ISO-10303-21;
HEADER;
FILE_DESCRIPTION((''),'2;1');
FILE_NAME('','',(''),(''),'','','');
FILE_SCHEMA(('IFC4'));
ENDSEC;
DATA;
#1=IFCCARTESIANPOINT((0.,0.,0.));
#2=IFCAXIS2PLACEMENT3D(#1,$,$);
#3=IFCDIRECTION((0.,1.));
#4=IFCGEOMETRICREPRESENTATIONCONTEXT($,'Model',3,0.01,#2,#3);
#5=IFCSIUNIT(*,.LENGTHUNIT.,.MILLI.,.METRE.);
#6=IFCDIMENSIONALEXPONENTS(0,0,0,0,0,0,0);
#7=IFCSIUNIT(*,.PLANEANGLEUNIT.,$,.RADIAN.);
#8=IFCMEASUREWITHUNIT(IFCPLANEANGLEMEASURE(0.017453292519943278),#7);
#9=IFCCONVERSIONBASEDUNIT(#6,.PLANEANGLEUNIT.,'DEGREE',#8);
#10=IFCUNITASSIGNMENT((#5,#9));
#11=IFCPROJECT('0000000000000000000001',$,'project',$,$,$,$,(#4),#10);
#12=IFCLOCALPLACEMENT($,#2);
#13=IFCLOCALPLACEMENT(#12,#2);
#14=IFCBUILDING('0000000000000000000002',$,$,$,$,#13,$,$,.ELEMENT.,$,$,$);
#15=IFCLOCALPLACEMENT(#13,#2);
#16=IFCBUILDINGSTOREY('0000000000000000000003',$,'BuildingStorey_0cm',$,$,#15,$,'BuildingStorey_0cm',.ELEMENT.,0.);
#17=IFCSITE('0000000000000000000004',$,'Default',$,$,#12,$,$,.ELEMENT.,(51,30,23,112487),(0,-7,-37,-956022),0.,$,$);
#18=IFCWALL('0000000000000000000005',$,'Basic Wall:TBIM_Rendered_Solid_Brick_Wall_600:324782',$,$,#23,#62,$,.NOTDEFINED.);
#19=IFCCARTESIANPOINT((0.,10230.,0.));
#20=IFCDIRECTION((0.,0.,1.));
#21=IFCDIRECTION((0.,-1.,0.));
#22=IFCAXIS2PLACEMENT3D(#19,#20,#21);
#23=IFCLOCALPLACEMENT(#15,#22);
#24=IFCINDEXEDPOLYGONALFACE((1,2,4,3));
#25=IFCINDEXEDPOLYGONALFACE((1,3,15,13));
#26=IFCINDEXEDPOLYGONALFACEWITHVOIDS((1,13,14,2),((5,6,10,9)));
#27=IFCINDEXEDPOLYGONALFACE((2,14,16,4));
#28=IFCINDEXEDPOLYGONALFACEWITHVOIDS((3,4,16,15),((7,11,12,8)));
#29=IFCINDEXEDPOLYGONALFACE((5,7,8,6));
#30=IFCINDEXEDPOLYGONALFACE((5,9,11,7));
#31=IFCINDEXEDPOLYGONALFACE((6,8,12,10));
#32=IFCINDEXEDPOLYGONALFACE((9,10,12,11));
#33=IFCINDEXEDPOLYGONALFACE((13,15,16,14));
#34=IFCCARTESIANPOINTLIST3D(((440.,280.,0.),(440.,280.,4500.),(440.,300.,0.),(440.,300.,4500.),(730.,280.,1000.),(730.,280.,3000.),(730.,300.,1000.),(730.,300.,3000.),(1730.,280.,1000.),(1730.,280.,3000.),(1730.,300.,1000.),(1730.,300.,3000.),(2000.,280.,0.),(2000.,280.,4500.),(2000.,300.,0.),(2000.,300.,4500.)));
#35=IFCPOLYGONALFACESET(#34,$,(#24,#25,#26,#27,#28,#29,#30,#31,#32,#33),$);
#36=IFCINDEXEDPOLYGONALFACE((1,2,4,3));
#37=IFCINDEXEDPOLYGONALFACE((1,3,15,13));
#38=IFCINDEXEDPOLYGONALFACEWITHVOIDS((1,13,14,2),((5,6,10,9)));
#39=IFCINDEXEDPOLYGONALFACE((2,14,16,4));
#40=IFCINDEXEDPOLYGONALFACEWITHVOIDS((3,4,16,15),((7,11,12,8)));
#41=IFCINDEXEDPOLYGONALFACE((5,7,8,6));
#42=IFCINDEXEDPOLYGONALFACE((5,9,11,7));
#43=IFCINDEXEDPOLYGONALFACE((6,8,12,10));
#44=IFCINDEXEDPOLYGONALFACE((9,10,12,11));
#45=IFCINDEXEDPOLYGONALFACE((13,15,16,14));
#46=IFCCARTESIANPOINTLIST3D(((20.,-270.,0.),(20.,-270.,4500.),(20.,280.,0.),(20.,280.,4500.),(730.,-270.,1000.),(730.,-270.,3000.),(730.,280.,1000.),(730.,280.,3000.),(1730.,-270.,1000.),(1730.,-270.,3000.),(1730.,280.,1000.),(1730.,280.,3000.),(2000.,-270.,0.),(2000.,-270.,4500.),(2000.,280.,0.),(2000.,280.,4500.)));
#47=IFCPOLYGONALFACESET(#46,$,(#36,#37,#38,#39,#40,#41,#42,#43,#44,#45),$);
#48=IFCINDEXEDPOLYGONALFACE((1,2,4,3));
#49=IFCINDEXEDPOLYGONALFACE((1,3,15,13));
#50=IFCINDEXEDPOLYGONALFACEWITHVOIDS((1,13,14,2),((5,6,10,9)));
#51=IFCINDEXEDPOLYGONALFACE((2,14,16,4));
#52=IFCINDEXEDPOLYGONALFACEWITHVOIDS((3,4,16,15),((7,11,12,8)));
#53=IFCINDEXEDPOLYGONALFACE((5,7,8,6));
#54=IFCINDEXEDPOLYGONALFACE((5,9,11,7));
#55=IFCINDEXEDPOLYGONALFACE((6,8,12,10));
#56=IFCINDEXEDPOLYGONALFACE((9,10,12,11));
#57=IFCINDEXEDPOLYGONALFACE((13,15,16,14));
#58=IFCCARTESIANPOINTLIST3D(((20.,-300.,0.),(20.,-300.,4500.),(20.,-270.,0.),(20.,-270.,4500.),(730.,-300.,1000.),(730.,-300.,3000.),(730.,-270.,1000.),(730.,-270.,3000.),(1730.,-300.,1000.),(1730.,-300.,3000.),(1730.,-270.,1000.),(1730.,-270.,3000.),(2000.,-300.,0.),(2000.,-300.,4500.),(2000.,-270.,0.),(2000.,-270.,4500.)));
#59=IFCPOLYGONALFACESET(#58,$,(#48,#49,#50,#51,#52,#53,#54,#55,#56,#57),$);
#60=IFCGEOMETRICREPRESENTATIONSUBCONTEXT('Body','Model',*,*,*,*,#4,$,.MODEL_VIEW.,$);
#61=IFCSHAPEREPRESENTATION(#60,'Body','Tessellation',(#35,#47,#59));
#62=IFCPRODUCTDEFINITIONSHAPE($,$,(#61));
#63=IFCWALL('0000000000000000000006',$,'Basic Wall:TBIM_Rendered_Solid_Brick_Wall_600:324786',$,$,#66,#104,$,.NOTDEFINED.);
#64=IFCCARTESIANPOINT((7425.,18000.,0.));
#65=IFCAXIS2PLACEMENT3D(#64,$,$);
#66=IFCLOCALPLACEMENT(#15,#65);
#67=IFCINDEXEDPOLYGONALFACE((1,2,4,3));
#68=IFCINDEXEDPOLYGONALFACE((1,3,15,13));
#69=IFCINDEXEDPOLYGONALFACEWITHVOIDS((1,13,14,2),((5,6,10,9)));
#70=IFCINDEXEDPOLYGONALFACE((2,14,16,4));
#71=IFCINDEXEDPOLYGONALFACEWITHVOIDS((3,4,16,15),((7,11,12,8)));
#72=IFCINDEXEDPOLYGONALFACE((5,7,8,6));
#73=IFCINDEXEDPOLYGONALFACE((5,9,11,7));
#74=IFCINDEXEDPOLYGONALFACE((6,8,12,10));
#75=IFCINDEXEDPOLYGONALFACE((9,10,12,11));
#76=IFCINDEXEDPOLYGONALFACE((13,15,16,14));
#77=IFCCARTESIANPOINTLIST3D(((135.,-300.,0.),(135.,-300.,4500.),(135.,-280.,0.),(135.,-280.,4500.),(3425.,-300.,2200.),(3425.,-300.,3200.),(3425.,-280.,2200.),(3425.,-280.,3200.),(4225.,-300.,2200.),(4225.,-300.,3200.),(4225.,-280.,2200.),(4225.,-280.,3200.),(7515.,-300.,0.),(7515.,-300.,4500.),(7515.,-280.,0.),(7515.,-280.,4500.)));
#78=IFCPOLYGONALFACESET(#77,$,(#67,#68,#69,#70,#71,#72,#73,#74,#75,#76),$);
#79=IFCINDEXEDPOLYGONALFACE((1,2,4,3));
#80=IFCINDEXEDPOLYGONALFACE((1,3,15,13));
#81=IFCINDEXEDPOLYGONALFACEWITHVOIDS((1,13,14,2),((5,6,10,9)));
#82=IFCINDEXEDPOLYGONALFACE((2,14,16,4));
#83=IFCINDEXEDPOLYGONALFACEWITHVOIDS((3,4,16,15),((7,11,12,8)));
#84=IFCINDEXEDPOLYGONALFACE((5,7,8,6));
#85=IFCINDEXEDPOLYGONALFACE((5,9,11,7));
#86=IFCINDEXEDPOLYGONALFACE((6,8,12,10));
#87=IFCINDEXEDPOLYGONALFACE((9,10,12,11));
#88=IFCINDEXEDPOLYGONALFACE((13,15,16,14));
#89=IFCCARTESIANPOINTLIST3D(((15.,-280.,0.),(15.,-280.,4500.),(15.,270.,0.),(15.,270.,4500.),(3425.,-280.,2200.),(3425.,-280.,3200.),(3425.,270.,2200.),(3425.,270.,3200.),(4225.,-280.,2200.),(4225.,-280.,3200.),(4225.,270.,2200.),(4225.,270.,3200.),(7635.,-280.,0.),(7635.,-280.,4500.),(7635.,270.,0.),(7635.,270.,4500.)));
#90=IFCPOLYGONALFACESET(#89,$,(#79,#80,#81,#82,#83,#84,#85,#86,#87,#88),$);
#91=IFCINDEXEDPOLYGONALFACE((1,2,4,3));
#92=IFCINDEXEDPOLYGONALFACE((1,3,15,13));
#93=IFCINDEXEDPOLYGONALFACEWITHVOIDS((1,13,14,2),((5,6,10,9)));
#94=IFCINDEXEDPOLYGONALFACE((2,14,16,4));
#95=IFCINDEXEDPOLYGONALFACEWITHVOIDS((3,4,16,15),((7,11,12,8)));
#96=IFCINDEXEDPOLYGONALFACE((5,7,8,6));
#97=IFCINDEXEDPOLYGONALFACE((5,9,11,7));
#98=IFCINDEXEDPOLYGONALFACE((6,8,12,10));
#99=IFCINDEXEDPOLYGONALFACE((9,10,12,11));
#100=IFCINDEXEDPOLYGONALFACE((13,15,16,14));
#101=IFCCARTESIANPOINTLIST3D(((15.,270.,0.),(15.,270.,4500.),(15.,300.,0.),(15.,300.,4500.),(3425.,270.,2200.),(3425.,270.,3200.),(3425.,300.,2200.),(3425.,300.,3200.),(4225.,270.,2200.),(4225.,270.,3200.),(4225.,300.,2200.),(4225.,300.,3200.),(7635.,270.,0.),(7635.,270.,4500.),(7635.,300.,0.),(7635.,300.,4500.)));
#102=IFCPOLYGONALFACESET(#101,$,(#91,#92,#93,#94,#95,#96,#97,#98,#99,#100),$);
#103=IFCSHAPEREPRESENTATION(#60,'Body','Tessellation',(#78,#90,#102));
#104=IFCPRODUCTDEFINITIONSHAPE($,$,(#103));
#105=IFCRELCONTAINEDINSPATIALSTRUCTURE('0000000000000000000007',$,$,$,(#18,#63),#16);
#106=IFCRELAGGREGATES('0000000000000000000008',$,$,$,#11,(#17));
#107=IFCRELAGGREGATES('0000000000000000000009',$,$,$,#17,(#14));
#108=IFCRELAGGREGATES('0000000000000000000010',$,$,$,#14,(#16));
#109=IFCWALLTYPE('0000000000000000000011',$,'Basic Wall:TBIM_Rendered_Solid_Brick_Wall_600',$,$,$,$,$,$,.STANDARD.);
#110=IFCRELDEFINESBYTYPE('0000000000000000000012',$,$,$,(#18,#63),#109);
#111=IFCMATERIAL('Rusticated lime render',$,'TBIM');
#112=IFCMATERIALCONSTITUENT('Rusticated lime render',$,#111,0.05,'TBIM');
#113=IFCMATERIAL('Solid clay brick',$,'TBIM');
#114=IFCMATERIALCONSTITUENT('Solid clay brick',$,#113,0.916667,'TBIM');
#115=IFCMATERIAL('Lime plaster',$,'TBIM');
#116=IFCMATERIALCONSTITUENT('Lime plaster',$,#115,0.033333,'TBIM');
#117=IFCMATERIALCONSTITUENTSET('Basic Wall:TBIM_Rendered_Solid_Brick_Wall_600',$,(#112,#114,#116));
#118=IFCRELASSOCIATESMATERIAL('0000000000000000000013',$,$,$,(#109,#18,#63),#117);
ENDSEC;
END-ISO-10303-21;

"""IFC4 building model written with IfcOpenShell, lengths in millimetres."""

from ifc_helpers import new_model, entity, si_unit, converted_unit, direction, frame, origin, place, context, subcontext, project, spatial, indexed_curve, outline, extrude, material, constituent, constituent_set, type_object, element, save


model = new_model("IFC4")

# Units and contexts
model_context = context("Model", 3, precision=0.01, world=origin(), true_north=direction((0.0, 1.0)))
body_context = subcontext(model_context, "Body", "Model", "MODEL_VIEW")
ifc_project = project(units=[si_unit("LENGTHUNIT", "METRE", prefix="MILLI"), converted_unit("PLANEANGLEUNIT", "DEGREE", entity("IfcPlaneAngleMeasure", 0.017453292519943278), si_unit("PLANEANGLEUNIT", "RADIAN"), dimensions=[0, 0, 0, 0, 0, 0, 0])], contexts=[model_context])

# Site, building, storey
site_placement = place(None, origin())
site = spatial("IfcSite", under=ifc_project, at=site_placement, Name="Default", CompositionType="ELEMENT", RefLatitude=(51, 30, 23, 112487), RefLongitude=(0, -7, -37, -956022), RefElevation=0.0)
building_placement = place(site_placement, origin())
building = spatial("IfcBuilding", under=site, at=building_placement, CompositionType="ELEMENT")
storey_placement = place(building_placement, origin())
storey = spatial("IfcBuildingStorey", under=building, at=storey_placement, Name="BuildingStorey_0cm", LongName="BuildingStorey_0cm", CompositionType="ELEMENT", Elevation=0.0)

# Walls, openings
ifc_material_1 = material(Name="Rusticated lime render", Category="TBIM")
ifc_constituent_1 = constituent(ifc_material_1, Name="Rusticated lime render", Category="TBIM", fraction=0.05)
ifc_material_2 = material(Name="Solid clay brick", Category="TBIM")
ifc_constituent_2 = constituent(ifc_material_2, Name="Solid clay brick", Category="TBIM", fraction=0.916667)
ifc_material_3 = material(Name="Lime plaster", Category="TBIM")
ifc_constituent_3 = constituent(ifc_material_3, Name="Lime plaster", Category="TBIM", fraction=0.033333)
ifc_constituent_set_1 = constituent_set(constituents=[ifc_constituent_1, ifc_constituent_2, ifc_constituent_3], Name="Basic Wall:TBIM_Rendered_Solid_Brick_Wall_600")
wall_type_1 = type_object("IfcWallType", Name="Basic Wall:TBIM_Rendered_Solid_Brick_Wall_600", PredefinedType="STANDARD", material=ifc_constituent_set_1)
wall_1_placement = place(storey_placement, frame((0.0, 10230.0, 0.0), z_axis=(0.0, 0.0, 1.0), x_axis=(0.0, -1.0, 0.0)))
wall_1 = element("IfcWall", 1, at=wall_1_placement, inside=storey, type_object=wall_type_1, material=ifc_constituent_set_1, Name="Basic Wall:TBIM_Rendered_Solid_Brick_Wall_600:324782", PredefinedType="NOTDEFINED", context=body_context, shape_type="SweptSolid", body=[
    extrude(outline(indexed_curve([(-2250.0, -780.0), (2250.0, -780.0), (2250.0, 780.0), (-2250.0, 780.0), (-2250.0, -780.0)], self_intersect=False), holes=[indexed_curve([(-1250.0, -490.0), (-1250.0, 510.0), (750.0, 510.0), (750.0, -490.0), (-1250.0, -490.0)], self_intersect=False)]), frame((1220.0, 280.0, 2250.0), z_axis=(0.0, 1.0, 0.0), x_axis=(0.0, 0.0, 1.0)), (0.0, 0.0, 1.0), 20.0),
    extrude(outline(indexed_curve([(-2250.0, -990.0), (2250.0, -990.0), (2250.0, 990.0), (-2250.0, 990.0), (-2250.0, -990.0)], self_intersect=False), holes=[indexed_curve([(-1250.0, -280.0), (-1250.0, 720.0), (750.0, 720.0), (750.0, -280.0), (-1250.0, -280.0)], self_intersect=False)]), frame((1010.0, -270.0, 2250.0), z_axis=(0.0, 1.0, 0.0), x_axis=(0.0, 0.0, 1.0)), (0.0, 0.0, 1.0), 550.0),
    extrude(outline(indexed_curve([(-2250.0, -990.0), (2250.0, -990.0), (2250.0, 990.0), (-2250.0, 990.0), (-2250.0, -990.0)], self_intersect=False), holes=[indexed_curve([(750.0, -280.0), (-1250.0, -280.0), (-1250.0, 720.0), (750.0, 720.0), (750.0, -280.0)], self_intersect=False)]), frame((1010.0, -300.0, 2250.0), z_axis=(0.0, 1.0, 0.0), x_axis=(0.0, 0.0, 1.0)), (0.0, 0.0, 1.0), 30.0),
])
opening_1_placement = place(wall_1_placement, frame((730.0, -300.0, 1000.0)))
element("IfcOpeningElement", 2, at=opening_1_placement, cuts=wall_1, PredefinedType="OPENING", context=body_context, shape_type="SweptSolid", body=[
    extrude(outline(indexed_curve([(2000.0, 0.0), (2000.0, 1000.0), (0.0, 1000.0), (0.0, 0.0), (2000.0, 0.0)], self_intersect=False)), frame((0.0, 0.0, 0.0), z_axis=(0.0, 1.0, 0.0), x_axis=(0.0, 0.0, 1.0)), (0.0, 0.0, 1.0), 600.0),
])
wall_2_placement = place(storey_placement, frame((7425.0, 18000.0, 0.0)))
wall_2 = element("IfcWall", 3, at=wall_2_placement, inside=storey, type_object=wall_type_1, material=ifc_constituent_set_1, Name="Basic Wall:TBIM_Rendered_Solid_Brick_Wall_600:324786", PredefinedType="NOTDEFINED", context=body_context, shape_type="SweptSolid", body=[
    extrude(outline(indexed_curve([(-2250.0, -3690.0), (2250.0, -3690.0), (2250.0, -3675.0), (2250.0, 3675.0), (2250.0, 3690.0), (-2250.0, 3690.0), (-2250.0, 3675.0), (-2250.0, -3675.0), (-2250.0, -3690.0)], self_intersect=False), holes=[indexed_curve([(950.0, -400.0), (-50.0, -400.0), (-50.0, 400.0), (950.0, 400.0), (950.0, -400.0)], self_intersect=False)]), frame((3825.0, -300.0, 2250.0), z_axis=(0.0, 1.0, 0.0), x_axis=(0.0, 0.0, 1.0)), (0.0, 0.0, 1.0), 20.0),
    extrude(outline(indexed_curve([(-2250.0, -3810.0), (2250.0, -3810.0), (2250.0, 3810.0), (-2250.0, 3810.0), (-2250.0, -3810.0)], self_intersect=False), holes=[indexed_curve([(-50.0, -400.0), (-50.0, 400.0), (950.0, 400.0), (950.0, -400.0), (-50.0, -400.0)], self_intersect=False)]), frame((3825.0, -280.0, 2250.0), z_axis=(0.0, 1.0, 0.0), x_axis=(0.0, 0.0, 1.0)), (0.0, 0.0, 1.0), 550.0),
    extrude(outline(indexed_curve([(-2250.0, -3810.0), (2250.0, -3810.0), (2250.0, 3810.0), (-2250.0, 3810.0), (-2250.0, -3810.0)], self_intersect=False), holes=[indexed_curve([(-50.0, -400.0), (-50.0, 400.0), (950.0, 400.0), (950.0, -400.0), (-50.0, -400.0)], self_intersect=False)]), frame((3825.0, 270.0, 2250.0), z_axis=(0.0, 1.0, 0.0), x_axis=(0.0, 0.0, 1.0)), (0.0, 0.0, 1.0), 30.0),
])
opening_2_placement = place(wall_2_placement, frame((3425.0, -300.0, 2200.0)))
element("IfcOpeningElement", 4, at=opening_2_placement, cuts=wall_2, PredefinedType="OPENING", context=body_context, shape_type="SweptSolid", body=[
    extrude(outline(indexed_curve([(1000.0, 0.0), (1000.0, 800.0), (0.0, 800.0), (0.0, 0.0), (1000.0, 0.0)], self_intersect=False)), frame((0.0, 0.0, 0.0), z_axis=(0.0, 1.0, 0.0), x_axis=(0.0, 0.0, 1.0)), (0.0, 0.0, 1.0), 600.0),
])

save(model, "model.ifc")
